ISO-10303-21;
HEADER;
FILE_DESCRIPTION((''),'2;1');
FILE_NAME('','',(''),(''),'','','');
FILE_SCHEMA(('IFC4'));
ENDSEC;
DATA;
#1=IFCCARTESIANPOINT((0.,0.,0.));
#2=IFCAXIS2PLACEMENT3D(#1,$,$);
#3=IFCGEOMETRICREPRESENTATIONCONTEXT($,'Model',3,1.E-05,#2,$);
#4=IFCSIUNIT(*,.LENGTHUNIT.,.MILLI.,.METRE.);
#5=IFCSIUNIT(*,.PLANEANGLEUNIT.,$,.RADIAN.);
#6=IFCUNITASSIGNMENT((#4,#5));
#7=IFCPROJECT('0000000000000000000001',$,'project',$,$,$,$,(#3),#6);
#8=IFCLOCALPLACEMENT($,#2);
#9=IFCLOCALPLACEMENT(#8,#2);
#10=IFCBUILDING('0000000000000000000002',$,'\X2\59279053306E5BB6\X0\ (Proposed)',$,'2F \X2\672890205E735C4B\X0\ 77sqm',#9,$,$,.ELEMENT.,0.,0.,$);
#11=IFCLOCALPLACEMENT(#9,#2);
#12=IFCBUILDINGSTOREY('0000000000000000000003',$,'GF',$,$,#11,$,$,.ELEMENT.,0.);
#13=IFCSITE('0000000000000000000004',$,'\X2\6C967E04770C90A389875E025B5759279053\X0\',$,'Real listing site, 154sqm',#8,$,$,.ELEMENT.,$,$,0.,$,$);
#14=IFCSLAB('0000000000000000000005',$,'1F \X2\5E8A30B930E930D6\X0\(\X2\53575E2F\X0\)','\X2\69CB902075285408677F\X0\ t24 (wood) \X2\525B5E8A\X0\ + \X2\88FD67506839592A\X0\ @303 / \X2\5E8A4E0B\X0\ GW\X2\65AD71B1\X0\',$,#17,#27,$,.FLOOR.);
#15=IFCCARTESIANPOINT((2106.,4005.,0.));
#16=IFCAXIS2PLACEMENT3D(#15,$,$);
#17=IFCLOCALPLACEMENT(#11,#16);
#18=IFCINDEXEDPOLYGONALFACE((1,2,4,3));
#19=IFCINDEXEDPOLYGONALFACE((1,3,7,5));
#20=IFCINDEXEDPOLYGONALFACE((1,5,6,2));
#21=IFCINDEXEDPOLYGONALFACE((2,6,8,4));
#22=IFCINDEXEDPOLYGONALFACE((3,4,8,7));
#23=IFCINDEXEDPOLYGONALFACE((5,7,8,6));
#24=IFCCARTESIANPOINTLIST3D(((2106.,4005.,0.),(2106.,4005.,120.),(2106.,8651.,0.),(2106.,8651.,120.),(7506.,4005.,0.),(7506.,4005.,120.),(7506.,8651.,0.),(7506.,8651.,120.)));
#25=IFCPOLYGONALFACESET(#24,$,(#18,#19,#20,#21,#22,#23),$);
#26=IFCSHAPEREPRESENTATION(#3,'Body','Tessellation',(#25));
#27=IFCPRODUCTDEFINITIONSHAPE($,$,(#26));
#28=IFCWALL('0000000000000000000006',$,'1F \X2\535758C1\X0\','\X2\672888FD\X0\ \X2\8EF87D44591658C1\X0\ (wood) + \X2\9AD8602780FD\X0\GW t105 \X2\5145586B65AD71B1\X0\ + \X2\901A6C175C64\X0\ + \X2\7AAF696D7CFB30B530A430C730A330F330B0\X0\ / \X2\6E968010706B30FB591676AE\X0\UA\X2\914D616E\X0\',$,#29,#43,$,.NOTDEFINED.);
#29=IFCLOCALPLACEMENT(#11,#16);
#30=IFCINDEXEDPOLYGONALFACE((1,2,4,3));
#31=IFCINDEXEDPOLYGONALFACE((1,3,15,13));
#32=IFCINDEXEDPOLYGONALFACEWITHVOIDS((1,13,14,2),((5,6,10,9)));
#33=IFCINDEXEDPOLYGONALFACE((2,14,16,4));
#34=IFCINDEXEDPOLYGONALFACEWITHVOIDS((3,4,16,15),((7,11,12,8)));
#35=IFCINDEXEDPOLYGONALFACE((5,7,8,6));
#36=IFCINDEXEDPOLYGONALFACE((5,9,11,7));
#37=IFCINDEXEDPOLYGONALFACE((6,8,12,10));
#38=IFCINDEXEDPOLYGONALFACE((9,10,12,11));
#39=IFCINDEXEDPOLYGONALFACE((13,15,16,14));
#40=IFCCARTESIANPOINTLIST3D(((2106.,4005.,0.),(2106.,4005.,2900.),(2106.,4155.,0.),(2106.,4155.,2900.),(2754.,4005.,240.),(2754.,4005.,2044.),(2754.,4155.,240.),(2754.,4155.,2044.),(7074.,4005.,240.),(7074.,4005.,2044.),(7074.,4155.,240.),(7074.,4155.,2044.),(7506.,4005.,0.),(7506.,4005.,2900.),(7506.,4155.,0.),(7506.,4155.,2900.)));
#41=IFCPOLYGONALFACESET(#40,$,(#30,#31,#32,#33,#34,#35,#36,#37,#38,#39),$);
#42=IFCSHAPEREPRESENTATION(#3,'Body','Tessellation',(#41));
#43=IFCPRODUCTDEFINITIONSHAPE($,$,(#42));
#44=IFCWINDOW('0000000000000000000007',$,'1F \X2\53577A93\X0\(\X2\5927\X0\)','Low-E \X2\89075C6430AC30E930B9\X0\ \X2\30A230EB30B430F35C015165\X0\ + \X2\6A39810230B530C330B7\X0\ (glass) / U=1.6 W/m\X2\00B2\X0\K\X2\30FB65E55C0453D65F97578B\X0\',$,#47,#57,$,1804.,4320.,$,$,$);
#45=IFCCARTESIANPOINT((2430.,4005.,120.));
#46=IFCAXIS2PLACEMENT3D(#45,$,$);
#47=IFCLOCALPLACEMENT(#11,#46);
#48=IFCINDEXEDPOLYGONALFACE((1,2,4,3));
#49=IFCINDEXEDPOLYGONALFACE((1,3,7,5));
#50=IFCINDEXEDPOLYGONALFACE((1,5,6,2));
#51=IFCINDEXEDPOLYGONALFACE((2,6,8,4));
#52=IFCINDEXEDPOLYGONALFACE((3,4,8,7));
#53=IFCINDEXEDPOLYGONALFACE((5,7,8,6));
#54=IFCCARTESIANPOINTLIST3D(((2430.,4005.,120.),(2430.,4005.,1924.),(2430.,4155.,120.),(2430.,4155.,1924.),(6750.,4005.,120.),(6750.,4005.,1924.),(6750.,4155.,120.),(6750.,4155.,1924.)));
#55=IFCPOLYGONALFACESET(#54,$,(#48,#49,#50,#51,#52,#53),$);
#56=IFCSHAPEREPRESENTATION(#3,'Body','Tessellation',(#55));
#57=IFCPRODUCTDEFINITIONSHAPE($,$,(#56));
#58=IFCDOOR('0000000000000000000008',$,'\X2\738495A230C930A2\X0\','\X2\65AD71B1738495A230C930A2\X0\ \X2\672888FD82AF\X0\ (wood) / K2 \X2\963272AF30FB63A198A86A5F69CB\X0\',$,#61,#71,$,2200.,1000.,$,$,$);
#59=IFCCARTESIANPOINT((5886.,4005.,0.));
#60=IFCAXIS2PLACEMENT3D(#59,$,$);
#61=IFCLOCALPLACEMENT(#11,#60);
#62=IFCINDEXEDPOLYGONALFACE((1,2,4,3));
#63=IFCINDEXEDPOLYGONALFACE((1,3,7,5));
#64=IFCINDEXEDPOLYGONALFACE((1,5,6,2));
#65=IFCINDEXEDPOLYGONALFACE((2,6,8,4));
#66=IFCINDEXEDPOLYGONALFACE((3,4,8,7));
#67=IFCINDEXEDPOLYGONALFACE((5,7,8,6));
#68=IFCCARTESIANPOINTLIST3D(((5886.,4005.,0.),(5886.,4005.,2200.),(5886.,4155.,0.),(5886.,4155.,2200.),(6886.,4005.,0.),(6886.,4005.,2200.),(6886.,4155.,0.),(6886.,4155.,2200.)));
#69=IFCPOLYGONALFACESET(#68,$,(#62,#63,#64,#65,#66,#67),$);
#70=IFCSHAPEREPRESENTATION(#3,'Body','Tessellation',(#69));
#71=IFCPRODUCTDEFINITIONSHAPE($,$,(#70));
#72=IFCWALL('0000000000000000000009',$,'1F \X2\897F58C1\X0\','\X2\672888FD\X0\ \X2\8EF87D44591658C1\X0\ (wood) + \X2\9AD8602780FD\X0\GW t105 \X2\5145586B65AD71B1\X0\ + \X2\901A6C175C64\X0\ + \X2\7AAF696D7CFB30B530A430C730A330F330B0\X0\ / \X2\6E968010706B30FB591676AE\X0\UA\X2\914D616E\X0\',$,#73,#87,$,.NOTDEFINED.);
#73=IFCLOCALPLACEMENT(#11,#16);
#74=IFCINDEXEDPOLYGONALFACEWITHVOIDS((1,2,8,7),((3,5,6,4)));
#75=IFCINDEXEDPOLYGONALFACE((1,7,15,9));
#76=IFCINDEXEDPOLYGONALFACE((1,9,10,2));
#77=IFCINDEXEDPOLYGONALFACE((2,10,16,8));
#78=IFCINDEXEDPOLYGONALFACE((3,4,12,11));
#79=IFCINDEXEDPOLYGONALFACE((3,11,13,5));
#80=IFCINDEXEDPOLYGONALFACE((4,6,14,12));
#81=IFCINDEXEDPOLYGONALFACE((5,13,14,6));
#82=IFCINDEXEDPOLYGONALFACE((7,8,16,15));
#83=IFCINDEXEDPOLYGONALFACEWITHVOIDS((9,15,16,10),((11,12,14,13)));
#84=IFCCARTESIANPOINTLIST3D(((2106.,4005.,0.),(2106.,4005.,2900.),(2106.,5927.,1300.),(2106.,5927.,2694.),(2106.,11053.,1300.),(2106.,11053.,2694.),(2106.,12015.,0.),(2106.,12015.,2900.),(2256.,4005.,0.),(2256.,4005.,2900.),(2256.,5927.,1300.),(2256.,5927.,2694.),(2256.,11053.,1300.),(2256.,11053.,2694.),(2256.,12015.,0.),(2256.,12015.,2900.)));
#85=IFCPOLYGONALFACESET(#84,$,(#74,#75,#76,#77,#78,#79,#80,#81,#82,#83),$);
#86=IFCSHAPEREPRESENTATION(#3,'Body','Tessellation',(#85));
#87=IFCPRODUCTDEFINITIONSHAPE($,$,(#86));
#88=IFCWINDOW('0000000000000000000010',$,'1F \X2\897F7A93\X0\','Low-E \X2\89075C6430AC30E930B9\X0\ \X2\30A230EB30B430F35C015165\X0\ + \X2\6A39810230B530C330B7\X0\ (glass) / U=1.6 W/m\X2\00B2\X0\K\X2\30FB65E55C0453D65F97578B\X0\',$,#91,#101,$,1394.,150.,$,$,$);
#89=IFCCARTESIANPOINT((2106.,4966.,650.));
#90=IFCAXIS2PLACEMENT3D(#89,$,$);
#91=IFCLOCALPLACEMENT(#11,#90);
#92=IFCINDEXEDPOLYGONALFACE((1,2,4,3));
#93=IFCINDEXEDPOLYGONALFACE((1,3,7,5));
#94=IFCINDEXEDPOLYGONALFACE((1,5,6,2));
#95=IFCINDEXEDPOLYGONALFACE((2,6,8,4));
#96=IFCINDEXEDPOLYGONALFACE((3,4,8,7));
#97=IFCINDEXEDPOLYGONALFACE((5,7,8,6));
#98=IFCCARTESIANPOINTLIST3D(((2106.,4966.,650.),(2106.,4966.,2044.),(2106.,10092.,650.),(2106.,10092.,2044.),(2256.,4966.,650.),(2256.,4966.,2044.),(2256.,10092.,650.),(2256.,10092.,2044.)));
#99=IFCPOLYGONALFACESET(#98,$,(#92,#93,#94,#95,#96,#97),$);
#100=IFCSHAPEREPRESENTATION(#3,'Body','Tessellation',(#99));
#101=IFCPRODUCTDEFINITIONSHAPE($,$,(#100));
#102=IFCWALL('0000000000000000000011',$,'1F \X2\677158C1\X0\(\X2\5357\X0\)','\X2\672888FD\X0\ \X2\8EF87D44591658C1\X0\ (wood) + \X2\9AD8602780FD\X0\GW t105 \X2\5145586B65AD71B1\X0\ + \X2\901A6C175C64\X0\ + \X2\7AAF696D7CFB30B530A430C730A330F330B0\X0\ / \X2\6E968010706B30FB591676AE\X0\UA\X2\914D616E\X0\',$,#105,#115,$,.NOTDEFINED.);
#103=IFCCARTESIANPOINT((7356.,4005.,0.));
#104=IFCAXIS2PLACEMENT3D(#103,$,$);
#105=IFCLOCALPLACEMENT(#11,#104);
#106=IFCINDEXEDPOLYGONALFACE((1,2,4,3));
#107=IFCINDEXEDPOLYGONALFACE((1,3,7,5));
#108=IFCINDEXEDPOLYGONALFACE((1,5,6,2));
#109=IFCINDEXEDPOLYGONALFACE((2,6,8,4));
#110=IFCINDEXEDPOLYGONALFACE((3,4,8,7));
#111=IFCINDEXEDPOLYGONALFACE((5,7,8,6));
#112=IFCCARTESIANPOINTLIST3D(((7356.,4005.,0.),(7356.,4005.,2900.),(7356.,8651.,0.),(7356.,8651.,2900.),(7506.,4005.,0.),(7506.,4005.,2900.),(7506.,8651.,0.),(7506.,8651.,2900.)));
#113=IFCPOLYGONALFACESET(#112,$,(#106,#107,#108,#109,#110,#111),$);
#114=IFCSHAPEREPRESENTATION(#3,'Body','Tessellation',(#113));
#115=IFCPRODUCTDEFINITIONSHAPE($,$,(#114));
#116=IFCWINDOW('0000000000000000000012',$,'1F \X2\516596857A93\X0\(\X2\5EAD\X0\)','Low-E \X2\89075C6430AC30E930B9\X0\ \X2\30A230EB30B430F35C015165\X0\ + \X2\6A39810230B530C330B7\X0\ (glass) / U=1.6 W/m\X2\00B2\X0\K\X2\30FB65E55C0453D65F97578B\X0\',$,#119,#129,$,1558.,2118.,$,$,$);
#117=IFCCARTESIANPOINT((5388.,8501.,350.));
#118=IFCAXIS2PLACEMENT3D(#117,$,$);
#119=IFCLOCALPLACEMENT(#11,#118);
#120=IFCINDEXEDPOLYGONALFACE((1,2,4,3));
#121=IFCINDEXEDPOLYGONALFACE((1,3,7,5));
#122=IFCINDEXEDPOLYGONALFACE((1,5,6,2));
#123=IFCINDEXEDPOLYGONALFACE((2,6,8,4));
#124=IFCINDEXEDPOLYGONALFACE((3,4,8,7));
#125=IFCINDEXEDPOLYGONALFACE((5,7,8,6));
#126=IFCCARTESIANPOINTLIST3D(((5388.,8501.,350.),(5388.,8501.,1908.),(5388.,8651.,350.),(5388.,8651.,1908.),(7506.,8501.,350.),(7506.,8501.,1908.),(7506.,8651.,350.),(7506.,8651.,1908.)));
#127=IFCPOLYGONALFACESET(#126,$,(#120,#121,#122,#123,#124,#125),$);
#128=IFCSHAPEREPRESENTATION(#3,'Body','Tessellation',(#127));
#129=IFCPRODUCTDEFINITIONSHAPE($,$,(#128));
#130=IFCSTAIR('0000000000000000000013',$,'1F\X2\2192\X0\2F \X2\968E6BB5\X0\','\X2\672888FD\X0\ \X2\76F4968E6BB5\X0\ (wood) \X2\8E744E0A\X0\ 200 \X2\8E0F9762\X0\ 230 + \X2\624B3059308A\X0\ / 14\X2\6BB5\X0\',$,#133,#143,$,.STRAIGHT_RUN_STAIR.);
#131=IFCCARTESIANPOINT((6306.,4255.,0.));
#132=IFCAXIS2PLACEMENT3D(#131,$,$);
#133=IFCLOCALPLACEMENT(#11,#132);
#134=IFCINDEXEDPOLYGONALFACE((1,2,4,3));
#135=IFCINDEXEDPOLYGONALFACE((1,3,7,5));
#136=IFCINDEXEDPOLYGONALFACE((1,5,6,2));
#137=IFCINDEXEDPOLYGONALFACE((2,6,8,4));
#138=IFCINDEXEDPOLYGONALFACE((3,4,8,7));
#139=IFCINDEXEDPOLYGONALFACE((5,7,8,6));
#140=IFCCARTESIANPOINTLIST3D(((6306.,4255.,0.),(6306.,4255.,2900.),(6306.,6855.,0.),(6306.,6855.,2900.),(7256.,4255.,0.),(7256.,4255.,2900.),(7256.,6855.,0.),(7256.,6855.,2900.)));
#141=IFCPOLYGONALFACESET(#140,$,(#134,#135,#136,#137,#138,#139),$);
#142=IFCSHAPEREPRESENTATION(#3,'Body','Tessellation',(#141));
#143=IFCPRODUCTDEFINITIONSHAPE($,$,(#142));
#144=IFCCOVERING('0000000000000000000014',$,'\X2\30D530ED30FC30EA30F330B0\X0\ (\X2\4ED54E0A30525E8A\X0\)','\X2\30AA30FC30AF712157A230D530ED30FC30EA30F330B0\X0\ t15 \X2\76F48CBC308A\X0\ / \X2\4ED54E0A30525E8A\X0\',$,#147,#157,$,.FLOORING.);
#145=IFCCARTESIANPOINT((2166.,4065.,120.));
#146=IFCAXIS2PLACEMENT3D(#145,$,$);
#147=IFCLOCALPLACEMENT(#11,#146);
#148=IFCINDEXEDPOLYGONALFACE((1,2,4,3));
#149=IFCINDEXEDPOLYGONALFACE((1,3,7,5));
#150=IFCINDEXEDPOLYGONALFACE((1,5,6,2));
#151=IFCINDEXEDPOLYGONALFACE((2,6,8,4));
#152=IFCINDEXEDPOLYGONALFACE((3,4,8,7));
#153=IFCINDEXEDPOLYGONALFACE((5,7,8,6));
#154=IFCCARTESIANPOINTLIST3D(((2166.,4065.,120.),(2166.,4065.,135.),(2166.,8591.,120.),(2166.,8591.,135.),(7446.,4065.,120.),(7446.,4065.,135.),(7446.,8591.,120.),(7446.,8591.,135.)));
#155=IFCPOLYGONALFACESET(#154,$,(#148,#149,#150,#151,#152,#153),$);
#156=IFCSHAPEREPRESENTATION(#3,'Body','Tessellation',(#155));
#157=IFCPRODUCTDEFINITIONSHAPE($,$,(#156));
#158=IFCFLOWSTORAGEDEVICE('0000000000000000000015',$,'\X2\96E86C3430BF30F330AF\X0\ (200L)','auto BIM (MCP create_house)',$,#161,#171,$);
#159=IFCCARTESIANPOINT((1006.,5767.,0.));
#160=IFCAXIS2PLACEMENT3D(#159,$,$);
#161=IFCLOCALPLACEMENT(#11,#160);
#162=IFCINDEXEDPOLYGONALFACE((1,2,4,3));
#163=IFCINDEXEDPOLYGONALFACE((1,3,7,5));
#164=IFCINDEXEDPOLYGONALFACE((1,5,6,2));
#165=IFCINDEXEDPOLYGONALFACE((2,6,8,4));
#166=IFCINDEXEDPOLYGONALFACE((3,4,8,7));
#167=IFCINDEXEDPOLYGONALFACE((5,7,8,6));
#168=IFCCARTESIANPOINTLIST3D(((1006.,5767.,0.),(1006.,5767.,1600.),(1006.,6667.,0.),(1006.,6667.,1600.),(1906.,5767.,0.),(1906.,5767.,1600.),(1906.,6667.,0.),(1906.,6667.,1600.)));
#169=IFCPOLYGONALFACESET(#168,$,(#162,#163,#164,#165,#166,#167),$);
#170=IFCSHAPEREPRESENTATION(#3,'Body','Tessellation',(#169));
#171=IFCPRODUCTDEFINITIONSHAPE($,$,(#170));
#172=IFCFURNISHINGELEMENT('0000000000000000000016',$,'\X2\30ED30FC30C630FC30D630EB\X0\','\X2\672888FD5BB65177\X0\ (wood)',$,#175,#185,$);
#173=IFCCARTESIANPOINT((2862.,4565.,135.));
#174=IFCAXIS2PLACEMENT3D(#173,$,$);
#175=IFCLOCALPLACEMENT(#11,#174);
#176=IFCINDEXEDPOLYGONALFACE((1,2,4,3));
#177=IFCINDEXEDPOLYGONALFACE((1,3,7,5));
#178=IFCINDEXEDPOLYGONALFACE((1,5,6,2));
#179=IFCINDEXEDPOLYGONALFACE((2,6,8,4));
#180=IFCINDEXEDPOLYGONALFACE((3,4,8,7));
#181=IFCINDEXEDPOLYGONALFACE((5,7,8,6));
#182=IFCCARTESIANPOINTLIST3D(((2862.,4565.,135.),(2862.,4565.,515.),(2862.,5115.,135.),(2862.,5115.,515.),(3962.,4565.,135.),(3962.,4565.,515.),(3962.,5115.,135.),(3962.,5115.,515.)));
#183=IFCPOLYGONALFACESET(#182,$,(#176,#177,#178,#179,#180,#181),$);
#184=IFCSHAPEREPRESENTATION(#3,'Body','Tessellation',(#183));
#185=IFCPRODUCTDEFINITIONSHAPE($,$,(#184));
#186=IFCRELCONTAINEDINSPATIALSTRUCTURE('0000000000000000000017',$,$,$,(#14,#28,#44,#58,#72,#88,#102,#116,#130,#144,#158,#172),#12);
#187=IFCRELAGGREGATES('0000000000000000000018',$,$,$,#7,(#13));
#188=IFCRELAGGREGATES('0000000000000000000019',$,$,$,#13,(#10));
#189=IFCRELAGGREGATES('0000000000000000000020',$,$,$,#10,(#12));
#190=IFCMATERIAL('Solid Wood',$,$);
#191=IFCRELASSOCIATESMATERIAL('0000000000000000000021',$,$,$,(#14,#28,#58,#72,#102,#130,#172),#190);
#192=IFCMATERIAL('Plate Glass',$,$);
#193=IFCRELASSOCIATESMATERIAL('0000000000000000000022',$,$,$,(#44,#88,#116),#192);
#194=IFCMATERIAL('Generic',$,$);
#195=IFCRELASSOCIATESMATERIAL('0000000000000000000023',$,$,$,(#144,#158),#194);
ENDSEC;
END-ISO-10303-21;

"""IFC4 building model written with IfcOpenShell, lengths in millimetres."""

from ifc_helpers import new_model, si_unit, frame, frame_2d, origin, place, context, project, spatial, rectangle, extrude, material, element, fill, save


model = new_model("IFC4")

# Units and contexts
model_context = context("Model", 3, precision=1e-05, world=origin())
ifc_project = project(units=[si_unit("LENGTHUNIT", "METRE", prefix="MILLI"), si_unit("PLANEANGLEUNIT", "RADIAN")], contexts=[model_context])

# Site, building, storey
site_placement = place(None, origin())
site = spatial("IfcSite", under=ifc_project, at=site_placement, Name="沖縄県那覇市字大道", ObjectType="Real listing site, 154sqm", CompositionType="ELEMENT", RefElevation=0.0)
building_placement = place(site_placement, origin())
building = spatial("IfcBuilding", under=site, at=building_placement, Name="大道の家 (Proposed)", ObjectType="2F 木造平屋 77sqm", CompositionType="ELEMENT", ElevationOfRefHeight=0.0, ElevationOfTerrain=0.0)
storey_placement = place(building_placement, origin())
storey = spatial("IfcBuildingStorey", under=building, at=storey_placement, Name="GF", CompositionType="ELEMENT", Elevation=0.0)

# Slab
ifc_material_1 = material(Name="Solid Wood")
slab_1_placement = place(storey_placement, frame((2106.0, 4005.0, 0.0)))
element("IfcSlab", 1, at=slab_1_placement, inside=storey, material=ifc_material_1, Name="1F 床スラブ(南帯)", Description="構造用合板 t24 (wood) 剛床 + 製材根太 @303 / 床下 GW断熱", PredefinedType="FLOOR", context=model_context, shape_type="SweptSolid", body=[
    extrude(rectangle(XDim=5400.0, YDim=4646.0, at=frame_2d((2700.0, 2323.0))), frame((2106.0, 4005.0, 0.0)), (0.0, 0.0, 1.0), 120.0),
])

# Wall, openings, window, door
wall_1_placement = place(storey_placement, frame((2106.0, 4005.0, 0.0)))
wall_1 = element("IfcWall", 2, at=wall_1_placement, inside=storey, material=ifc_material_1, Name="1F 南壁", Description="木製 軸組外壁 (wood) + 高性能GW t105 充填断熱 + 通気層 + 窯業系サイディング / 準耐火・外皮UA配慮", PredefinedType="NOTDEFINED", context=model_context, shape_type="SweptSolid", body=[
    extrude(rectangle(XDim=5400.0, YDim=150.0, at=frame_2d((2700.0, 75.0))), frame((2106.0, 4005.0, 0.0)), (0.0, 0.0, 1.0), 2900.0),
])
opening_1_placement = place(storey_placement, frame((2430.0, 4005.0, 120.0)))
opening_1 = element("IfcOpeningElement", 3, at=opening_1_placement, cuts=wall_1, PredefinedType="NOTDEFINED", context=model_context, shape_type="SweptSolid", body=[
    extrude(rectangle(XDim=4320.0, YDim=150.0, at=frame_2d((2160.0, 75.0))), frame((2430.0, 4005.0, 120.0)), (0.0, 0.0, 1.0), 1804.0),
])
opening_2_placement = place(storey_placement, frame((5886.0, 4005.0, 0.0)))
opening_2 = element("IfcOpeningElement", 4, at=opening_2_placement, cuts=wall_1, PredefinedType="NOTDEFINED", context=model_context, shape_type="SweptSolid", body=[
    extrude(rectangle(XDim=1000.0, YDim=150.0, at=frame_2d((500.0, 75.0))), frame((5886.0, 4005.0, 0.0)), (0.0, 0.0, 1.0), 2200.0),
])
ifc_material_2 = material(Name="Plate Glass")
window_1_placement = place(storey_placement, frame((2430.0, 4005.0, 120.0)))
window_1 = element("IfcWindow", 5, at=window_1_placement, inside=storey, material=ifc_material_2, Name="1F 南窓(大)", Description="Low-E 複層ガラス アルゴン封入 + 樹脂サッシ (glass) / U=1.6 W/m²K・日射取得型", OverallHeight=1804.0, OverallWidth=4320.0, context=model_context, shape_type="SweptSolid", body=[
    extrude(rectangle(XDim=4320.0, YDim=150.0, at=frame_2d((2160.0, 75.0))), frame((2430.0, 4005.0, 120.0)), (0.0, 0.0, 1.0), 1804.0),
])
fill(opening_1, window_1)
door_1_placement = place(storey_placement, frame((5886.0, 4005.0, 0.0)))
door_1 = element("IfcDoor", 6, at=door_1_placement, inside=storey, material=ifc_material_1, Name="玄関ドア", Description="断熱玄関ドア 木製芯 (wood) / K2 防犯・採風機構", OverallHeight=2200.0, OverallWidth=1000.0, context=model_context, shape_type="SweptSolid", body=[
    extrude(rectangle(XDim=1000.0, YDim=150.0, at=frame_2d((500.0, 75.0))), frame((5886.0, 4005.0, 0.0)), (0.0, 0.0, 1.0), 2200.0),
])
fill(opening_2, door_1)

# Walls, openings, windows
wall_2_placement = place(storey_placement, frame((2106.0, 4005.0, 0.0)))
wall_2 = element("IfcWall", 7, at=wall_2_placement, inside=storey, material=ifc_material_1, Name="1F 西壁", Description="木製 軸組外壁 (wood) + 高性能GW t105 充填断熱 + 通気層 + 窯業系サイディング / 準耐火・外皮UA配慮", PredefinedType="NOTDEFINED", context=model_context, shape_type="SweptSolid", body=[
    extrude(rectangle(XDim=150.0, YDim=8010.0, at=frame_2d((75.0, 4005.0))), frame((2106.0, 4005.0, 0.0)), (0.0, 0.0, 1.0), 2900.0),
])
opening_3_placement = place(storey_placement, frame((2106.0, 4966.0, 650.0)))
opening_3 = element("IfcOpeningElement", 8, at=opening_3_placement, cuts=wall_2, PredefinedType="NOTDEFINED", context=model_context, shape_type="SweptSolid", body=[
    extrude(rectangle(XDim=150.0, YDim=5126.0, at=frame_2d((75.0, 2563.0))), frame((2106.0, 4966.0, 650.0)), (0.0, 0.0, 1.0), 1394.0),
])
window_2_placement = place(storey_placement, frame((2106.0, 4966.0, 650.0)))
window_2 = element("IfcWindow", 9, at=window_2_placement, inside=storey, material=ifc_material_2, Name="1F 西窓", Description="Low-E 複層ガラス アルゴン封入 + 樹脂サッシ (glass) / U=1.6 W/m²K・日射取得型", OverallHeight=1394.0, OverallWidth=150.0, context=model_context, shape_type="SweptSolid", body=[
    extrude(rectangle(XDim=150.0, YDim=5126.0, at=frame_2d((75.0, 2563.0))), frame((2106.0, 4966.0, 650.0)), (0.0, 0.0, 1.0), 1394.0),
])
fill(opening_3, window_2)
wall_3_placement = place(storey_placement, frame((7356.0, 4005.0, 0.0)))
wall_3 = element("IfcWall", 10, at=wall_3_placement, inside=storey, material=ifc_material_1, Name="1F 東壁(南)", Description="木製 軸組外壁 (wood) + 高性能GW t105 充填断熱 + 通気層 + 窯業系サイディング / 準耐火・外皮UA配慮", PredefinedType="NOTDEFINED", context=model_context, shape_type="SweptSolid", body=[
    extrude(rectangle(XDim=150.0, YDim=4646.0, at=frame_2d((75.0, 2323.0))), frame((7356.0, 4005.0, 0.0)), (0.0, 0.0, 1.0), 2900.0),
])
opening_4_placement = place(storey_placement, frame((5388.0, 8501.0, 350.0)))
opening_4 = element("IfcOpeningElement", 11, at=opening_4_placement, cuts=wall_3, PredefinedType="NOTDEFINED", context=model_context, shape_type="SweptSolid", body=[
    extrude(rectangle(XDim=2118.0, YDim=150.0, at=frame_2d((1059.0, 75.0))), frame((5388.0, 8501.0, 350.0)), (0.0, 0.0, 1.0), 1558.0),
])
window_3_placement = place(storey_placement, frame((5388.0, 8501.0, 350.0)))
window_3 = element("IfcWindow", 12, at=window_3_placement, inside=storey, material=ifc_material_2, Name="1F 入隅窓(庭)", Description="Low-E 複層ガラス アルゴン封入 + 樹脂サッシ (glass) / U=1.6 W/m²K・日射取得型", OverallHeight=1558.0, OverallWidth=2118.0, context=model_context, shape_type="SweptSolid", body=[
    extrude(rectangle(XDim=2118.0, YDim=150.0, at=frame_2d((1059.0, 75.0))), frame((5388.0, 8501.0, 350.0)), (0.0, 0.0, 1.0), 1558.0),
])
fill(opening_4, window_3)

# Stair
stair_placement = place(storey_placement, frame((6306.0, 4255.0, 0.0)))
element("IfcStair", 13, at=stair_placement, inside=storey, material=ifc_material_1, Name="1F→2F 階段", Description="木製 直階段 (wood) 蹴上 200 踏面 230 + 手すり / 14段", PredefinedType="STRAIGHT_RUN_STAIR", context=model_context, shape_type="SweptSolid", body=[
    extrude(rectangle(XDim=950.0, YDim=2600.0, at=frame_2d((475.0, 1300.0))), frame((6306.0, 4255.0, 0.0)), (0.0, 0.0, 1.0), 2900.0),
])

# Covering
ifc_material_3 = material(Name="Generic")
covering_placement = place(storey_placement, frame((2166.0, 4065.0, 120.0)))
element("IfcCovering", 14, at=covering_placement, inside=storey, material=ifc_material_3, Name="フローリング (仕上げ床)", Description="オーク無垢フローリング t15 直貼り / 仕上げ床", PredefinedType="FLOORING", context=model_context, shape_type="SweptSolid", body=[
    extrude(rectangle(XDim=5280.0, YDim=4526.0, at=frame_2d((2640.0, 2263.0))), frame((2166.0, 4065.0, 120.0)), (0.0, 0.0, 1.0), 15.0),
])

# Flow storage device
flow_storage_device_placement = place(storey_placement, frame((1006.0, 5767.0, 0.0)))
element("IfcFlowStorageDevice", 15, at=flow_storage_device_placement, inside=storey, material=ifc_material_3, Name="雨水タンク (200L)", Description="auto BIM (MCP create_house)", context=model_context, shape_type="SweptSolid", body=[
    extrude(rectangle(XDim=900.0, YDim=900.0, at=frame_2d((450.0, 450.0))), frame((1006.0, 5767.0, 0.0)), (0.0, 0.0, 1.0), 1600.0),
])

# Furnishing element
furnishing_1_placement = place(storey_placement, frame((2862.0, 4565.0, 135.0)))
element("IfcFurnishingElement", 16, at=furnishing_1_placement, inside=storey, material=ifc_material_1, Name="ローテーブル", Description="木製家具 (wood)", context=model_context, shape_type="SweptSolid", body=[
    extrude(rectangle(XDim=1100.0, YDim=550.0, at=frame_2d((550.0, 275.0))), frame((2862.0, 4565.0, 135.0)), (0.0, 0.0, 1.0), 380.0),
])

save(model, "model.ifc")
